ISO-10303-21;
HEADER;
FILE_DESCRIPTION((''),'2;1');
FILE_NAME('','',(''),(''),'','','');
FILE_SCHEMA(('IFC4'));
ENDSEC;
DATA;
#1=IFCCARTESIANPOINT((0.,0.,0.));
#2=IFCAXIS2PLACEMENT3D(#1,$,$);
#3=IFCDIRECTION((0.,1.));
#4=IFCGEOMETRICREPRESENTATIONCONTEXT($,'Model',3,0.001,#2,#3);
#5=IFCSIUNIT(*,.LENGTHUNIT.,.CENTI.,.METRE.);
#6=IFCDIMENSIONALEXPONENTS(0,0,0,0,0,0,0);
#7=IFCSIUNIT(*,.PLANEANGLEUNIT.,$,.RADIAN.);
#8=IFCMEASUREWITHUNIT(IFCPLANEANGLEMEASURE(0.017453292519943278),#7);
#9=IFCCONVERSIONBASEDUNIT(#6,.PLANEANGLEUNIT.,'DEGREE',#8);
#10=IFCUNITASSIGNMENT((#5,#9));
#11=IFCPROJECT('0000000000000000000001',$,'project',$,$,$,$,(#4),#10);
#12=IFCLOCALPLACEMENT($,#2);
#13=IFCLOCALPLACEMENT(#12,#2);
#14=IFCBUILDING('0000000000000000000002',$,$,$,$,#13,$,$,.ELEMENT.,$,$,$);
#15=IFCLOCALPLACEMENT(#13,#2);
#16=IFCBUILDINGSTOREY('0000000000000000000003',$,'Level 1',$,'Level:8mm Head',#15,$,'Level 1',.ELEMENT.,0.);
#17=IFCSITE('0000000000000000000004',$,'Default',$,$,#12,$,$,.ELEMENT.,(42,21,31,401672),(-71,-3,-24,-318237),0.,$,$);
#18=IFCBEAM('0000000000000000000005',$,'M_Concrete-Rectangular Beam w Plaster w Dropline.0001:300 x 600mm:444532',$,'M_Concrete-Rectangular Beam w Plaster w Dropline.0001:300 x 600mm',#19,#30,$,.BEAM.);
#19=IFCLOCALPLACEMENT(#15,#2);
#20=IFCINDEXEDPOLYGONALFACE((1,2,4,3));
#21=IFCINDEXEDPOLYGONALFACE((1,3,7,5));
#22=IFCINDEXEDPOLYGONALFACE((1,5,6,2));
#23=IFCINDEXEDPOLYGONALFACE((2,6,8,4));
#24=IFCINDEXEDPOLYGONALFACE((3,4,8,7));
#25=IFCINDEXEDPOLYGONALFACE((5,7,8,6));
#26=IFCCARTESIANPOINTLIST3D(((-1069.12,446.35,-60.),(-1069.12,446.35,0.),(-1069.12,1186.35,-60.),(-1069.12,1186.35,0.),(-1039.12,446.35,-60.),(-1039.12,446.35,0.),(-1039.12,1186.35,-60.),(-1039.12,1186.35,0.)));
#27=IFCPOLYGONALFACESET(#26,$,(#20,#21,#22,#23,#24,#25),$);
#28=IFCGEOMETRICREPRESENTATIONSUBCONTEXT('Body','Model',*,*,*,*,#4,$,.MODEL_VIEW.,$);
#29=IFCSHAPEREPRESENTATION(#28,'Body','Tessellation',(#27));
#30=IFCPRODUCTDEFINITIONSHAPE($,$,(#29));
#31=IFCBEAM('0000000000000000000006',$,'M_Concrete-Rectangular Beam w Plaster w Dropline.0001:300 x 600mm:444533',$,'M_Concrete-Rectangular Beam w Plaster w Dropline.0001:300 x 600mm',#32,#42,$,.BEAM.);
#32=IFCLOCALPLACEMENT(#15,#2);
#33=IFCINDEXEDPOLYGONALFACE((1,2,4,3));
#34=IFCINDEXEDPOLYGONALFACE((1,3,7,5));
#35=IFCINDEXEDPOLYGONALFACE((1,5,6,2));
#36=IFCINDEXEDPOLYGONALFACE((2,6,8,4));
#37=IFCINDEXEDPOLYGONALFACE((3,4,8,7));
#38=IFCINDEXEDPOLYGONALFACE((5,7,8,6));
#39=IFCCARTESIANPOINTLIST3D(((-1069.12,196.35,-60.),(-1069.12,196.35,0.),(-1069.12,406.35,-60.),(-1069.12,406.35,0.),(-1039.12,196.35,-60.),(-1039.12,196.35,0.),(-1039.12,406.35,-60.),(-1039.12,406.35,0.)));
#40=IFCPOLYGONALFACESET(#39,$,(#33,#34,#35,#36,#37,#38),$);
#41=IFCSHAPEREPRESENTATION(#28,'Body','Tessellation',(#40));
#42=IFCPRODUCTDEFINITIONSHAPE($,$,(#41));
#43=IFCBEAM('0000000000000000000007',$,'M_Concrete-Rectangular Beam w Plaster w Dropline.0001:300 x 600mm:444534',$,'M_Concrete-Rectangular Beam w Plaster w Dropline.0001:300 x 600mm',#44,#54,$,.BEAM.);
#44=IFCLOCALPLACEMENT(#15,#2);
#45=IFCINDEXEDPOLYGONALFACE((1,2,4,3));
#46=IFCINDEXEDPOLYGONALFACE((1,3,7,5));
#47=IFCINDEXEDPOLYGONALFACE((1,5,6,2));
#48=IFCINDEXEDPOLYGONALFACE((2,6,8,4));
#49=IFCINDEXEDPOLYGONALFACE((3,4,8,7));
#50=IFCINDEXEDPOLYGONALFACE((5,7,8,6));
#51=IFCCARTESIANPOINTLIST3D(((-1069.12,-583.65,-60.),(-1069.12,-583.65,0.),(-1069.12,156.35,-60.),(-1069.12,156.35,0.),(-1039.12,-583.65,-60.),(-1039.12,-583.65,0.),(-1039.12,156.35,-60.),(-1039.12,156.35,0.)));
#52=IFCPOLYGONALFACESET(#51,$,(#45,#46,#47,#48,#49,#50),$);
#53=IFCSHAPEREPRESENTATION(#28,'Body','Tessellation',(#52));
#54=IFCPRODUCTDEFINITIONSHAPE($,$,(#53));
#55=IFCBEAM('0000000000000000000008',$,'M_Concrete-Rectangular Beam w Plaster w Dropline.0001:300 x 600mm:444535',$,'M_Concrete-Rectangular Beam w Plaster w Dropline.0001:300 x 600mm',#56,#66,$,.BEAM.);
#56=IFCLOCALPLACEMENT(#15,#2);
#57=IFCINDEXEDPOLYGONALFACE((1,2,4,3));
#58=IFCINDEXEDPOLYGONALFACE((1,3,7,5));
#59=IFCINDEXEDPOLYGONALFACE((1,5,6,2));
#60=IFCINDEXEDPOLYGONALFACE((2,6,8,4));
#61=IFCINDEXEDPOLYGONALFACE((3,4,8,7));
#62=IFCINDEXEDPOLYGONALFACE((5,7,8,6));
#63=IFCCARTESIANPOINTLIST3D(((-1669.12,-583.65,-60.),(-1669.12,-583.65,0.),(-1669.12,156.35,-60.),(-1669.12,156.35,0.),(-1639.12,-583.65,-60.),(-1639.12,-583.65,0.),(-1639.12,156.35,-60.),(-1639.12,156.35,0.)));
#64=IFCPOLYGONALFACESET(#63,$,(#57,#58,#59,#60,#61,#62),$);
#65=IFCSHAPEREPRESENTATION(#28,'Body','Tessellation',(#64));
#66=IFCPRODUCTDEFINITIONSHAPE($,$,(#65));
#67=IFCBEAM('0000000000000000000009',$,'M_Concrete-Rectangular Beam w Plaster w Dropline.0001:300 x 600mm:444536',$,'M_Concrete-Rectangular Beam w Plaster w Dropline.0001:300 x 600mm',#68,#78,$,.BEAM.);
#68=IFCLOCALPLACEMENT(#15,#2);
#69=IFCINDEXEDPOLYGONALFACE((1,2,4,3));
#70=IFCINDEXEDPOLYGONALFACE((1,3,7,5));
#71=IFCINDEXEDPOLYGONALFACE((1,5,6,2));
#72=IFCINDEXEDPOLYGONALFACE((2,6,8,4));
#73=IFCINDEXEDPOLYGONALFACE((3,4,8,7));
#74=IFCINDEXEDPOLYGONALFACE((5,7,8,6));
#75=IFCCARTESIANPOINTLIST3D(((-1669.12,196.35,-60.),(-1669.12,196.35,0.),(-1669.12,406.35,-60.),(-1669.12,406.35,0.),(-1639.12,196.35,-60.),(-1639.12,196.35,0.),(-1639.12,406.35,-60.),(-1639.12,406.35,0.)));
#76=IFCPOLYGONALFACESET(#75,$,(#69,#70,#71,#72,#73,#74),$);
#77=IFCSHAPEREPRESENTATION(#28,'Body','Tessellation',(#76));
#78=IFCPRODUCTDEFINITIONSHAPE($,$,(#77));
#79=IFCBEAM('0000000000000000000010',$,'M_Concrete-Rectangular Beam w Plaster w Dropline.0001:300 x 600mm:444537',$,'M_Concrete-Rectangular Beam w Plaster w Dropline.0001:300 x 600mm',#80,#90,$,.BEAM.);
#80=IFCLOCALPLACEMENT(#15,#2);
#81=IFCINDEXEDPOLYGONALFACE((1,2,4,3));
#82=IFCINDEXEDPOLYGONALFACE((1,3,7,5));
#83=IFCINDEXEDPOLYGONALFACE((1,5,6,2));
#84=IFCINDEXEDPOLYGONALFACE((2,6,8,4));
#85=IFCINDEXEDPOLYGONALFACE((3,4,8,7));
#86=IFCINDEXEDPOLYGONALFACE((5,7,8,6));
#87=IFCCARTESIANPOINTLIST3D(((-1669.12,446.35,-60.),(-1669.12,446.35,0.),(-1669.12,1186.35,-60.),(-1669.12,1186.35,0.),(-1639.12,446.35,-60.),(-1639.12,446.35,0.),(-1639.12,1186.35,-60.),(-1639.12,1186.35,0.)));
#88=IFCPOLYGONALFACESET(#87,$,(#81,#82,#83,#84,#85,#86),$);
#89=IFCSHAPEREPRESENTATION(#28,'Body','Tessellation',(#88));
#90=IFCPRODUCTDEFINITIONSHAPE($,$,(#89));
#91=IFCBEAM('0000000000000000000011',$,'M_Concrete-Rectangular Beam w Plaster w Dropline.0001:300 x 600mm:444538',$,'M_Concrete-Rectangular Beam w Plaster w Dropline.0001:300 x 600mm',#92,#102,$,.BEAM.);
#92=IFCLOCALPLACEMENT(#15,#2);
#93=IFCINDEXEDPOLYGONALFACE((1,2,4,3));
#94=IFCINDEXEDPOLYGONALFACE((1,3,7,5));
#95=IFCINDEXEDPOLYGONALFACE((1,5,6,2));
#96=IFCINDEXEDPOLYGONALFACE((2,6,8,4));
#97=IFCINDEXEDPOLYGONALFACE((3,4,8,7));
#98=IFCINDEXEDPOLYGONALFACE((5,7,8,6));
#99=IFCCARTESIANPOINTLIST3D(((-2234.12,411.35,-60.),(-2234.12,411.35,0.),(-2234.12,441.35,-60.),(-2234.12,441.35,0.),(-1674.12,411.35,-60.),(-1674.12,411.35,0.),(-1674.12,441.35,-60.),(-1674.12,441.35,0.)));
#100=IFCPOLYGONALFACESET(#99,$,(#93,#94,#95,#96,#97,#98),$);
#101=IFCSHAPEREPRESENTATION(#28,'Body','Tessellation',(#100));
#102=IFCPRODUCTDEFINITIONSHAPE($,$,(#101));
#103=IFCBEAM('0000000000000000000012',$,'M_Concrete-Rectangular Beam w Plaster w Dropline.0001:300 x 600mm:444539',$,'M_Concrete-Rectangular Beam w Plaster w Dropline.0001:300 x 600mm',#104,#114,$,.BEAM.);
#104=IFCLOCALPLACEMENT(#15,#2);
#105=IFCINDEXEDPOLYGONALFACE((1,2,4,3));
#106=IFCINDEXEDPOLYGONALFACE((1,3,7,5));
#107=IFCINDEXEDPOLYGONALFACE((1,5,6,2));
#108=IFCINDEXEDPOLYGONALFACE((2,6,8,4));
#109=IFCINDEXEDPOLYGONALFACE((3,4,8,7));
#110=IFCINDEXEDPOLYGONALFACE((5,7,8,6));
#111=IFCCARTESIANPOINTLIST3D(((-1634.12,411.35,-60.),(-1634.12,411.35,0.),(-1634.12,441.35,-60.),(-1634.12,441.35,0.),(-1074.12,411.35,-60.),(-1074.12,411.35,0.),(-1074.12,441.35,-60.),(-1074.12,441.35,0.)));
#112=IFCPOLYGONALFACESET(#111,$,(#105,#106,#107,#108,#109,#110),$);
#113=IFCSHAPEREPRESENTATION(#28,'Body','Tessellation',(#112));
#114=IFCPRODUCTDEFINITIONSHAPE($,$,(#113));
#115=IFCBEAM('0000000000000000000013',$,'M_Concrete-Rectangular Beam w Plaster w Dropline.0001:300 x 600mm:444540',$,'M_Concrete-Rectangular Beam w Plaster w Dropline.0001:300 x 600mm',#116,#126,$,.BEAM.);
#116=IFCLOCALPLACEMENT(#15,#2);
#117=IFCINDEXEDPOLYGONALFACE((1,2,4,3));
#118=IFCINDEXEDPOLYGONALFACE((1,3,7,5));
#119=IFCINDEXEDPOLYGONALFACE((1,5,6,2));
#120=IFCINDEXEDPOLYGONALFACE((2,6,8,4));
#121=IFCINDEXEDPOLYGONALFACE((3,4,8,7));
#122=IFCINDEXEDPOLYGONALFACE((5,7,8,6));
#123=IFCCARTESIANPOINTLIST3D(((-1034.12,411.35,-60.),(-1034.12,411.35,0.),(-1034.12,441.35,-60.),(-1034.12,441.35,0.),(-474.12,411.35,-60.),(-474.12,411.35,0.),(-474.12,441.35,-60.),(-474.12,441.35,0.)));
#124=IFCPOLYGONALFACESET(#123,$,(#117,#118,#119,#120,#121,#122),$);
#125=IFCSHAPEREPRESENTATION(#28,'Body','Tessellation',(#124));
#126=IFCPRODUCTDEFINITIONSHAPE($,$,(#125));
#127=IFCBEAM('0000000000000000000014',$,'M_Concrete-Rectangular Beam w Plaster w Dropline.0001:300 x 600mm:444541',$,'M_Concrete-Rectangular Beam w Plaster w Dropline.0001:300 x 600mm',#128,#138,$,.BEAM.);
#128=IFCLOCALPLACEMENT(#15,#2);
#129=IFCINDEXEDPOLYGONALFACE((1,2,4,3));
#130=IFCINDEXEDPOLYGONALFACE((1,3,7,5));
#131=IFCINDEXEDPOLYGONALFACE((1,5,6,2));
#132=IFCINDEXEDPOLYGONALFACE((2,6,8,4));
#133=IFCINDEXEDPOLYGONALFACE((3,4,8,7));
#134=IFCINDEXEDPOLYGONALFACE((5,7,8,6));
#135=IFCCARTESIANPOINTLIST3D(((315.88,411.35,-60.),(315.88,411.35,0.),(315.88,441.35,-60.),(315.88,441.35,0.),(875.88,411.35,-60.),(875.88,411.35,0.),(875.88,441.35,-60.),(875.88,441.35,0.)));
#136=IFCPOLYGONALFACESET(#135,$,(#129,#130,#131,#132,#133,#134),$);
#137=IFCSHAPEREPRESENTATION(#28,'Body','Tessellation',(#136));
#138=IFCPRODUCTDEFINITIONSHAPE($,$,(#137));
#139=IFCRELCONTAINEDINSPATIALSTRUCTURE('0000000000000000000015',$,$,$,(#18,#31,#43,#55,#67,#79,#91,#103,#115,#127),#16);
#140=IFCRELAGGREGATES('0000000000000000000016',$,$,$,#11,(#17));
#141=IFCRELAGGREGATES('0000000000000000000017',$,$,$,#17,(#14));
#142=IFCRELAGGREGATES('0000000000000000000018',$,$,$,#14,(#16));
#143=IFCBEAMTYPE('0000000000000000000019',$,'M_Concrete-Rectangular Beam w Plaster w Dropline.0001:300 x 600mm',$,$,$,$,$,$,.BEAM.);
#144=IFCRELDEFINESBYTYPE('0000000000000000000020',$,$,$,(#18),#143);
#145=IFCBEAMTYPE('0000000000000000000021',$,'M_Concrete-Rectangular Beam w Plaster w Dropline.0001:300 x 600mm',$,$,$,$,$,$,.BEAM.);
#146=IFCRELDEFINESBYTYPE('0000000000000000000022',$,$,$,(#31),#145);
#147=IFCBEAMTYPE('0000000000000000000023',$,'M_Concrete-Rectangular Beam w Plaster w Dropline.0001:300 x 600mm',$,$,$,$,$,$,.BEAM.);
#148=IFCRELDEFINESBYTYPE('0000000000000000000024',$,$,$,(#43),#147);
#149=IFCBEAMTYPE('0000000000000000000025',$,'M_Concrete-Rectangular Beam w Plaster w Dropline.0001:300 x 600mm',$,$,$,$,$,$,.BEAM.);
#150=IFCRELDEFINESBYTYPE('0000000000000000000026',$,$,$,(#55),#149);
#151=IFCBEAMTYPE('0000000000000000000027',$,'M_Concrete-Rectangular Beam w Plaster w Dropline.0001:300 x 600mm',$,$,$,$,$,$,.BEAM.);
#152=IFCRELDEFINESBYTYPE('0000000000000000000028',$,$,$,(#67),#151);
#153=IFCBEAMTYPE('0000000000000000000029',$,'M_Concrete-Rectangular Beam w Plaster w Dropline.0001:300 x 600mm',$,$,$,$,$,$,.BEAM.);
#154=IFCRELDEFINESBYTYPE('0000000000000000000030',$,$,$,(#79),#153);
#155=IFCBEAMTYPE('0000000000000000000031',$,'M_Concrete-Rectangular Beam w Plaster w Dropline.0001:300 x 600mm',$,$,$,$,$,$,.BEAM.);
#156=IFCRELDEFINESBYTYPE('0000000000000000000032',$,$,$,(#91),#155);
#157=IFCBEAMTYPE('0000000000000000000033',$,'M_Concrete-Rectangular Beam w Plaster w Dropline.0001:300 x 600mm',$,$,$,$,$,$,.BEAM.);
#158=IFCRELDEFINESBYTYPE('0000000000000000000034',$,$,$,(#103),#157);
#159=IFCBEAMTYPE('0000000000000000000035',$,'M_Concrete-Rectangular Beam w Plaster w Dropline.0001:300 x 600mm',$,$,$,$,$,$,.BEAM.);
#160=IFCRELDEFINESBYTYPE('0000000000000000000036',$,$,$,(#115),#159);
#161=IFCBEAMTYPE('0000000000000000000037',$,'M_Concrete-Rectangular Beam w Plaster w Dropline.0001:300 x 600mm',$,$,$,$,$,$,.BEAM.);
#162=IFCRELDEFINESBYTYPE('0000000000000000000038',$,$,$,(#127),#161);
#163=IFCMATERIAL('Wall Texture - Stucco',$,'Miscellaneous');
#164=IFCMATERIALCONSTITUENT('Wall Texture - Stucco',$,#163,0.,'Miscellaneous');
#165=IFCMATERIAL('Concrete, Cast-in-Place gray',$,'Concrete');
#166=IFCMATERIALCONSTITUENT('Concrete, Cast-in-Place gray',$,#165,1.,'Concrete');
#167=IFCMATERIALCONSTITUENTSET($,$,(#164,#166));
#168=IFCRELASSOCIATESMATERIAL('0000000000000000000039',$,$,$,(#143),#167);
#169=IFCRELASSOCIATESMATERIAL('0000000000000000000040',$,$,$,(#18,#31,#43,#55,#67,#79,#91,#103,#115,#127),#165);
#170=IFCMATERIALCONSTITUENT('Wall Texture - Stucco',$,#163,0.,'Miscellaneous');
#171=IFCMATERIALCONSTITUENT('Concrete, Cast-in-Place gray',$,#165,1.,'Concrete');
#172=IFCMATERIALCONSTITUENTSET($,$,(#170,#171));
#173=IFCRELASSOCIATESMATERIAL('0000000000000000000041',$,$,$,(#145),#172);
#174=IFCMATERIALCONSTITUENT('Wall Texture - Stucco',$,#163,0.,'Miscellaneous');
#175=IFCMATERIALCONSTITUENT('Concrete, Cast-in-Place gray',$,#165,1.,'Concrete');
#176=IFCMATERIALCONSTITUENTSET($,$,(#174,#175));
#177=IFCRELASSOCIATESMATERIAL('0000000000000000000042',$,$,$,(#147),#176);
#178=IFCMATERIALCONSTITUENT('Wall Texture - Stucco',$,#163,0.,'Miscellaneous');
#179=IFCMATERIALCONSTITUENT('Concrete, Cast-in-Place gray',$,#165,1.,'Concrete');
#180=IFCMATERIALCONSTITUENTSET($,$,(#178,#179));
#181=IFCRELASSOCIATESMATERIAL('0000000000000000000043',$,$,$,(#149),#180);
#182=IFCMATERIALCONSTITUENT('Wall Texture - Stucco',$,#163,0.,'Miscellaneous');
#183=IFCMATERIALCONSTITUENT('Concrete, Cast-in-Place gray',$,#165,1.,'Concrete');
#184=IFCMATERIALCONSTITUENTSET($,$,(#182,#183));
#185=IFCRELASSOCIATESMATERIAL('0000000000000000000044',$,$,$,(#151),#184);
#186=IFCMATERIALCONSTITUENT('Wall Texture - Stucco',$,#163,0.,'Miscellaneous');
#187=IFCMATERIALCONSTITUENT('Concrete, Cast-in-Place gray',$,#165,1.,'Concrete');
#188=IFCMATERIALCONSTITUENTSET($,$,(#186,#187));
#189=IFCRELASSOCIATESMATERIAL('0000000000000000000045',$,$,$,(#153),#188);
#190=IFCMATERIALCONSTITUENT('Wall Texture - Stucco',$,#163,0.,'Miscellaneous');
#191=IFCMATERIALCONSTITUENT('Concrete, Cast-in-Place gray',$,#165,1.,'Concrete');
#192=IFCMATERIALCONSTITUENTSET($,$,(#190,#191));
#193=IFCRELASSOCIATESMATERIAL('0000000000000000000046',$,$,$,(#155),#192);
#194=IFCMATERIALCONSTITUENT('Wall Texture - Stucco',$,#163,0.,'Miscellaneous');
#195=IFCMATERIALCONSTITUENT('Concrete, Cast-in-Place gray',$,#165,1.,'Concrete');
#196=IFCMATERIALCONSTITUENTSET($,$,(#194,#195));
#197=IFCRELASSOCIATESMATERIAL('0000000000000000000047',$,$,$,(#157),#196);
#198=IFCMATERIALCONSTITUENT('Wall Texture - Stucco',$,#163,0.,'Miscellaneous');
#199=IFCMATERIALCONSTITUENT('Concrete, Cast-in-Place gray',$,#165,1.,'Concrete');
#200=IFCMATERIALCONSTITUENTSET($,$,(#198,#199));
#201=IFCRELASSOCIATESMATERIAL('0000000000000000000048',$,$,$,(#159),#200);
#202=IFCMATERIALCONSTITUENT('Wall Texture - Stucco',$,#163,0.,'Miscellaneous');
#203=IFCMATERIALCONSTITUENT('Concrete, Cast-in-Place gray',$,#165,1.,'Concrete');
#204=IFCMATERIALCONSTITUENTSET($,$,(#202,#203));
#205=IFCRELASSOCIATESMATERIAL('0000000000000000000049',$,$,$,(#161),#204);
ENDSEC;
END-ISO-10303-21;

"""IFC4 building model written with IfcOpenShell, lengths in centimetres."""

from ifc_helpers import new_model, entity, si_unit, converted_unit, direction, frame, origin, place, context, subcontext, project, spatial, indexed_curve, outline, extrude, source, transform, mapped, material, constituent, constituent_set, type_object, type_shapes, element, save


model = new_model("IFC4")

# Units and contexts
model_context = context("Model", 3, precision=0.001, world=origin(), true_north=direction((0.0, 1.0)))
body_context = subcontext(model_context, "Body", "Model", "MODEL_VIEW")
ifc_project = project(units=[si_unit("LENGTHUNIT", "METRE", prefix="CENTI"), converted_unit("PLANEANGLEUNIT", "DEGREE", entity("IfcPlaneAngleMeasure", 0.017453292519943278), si_unit("PLANEANGLEUNIT", "RADIAN"), dimensions=[0, 0, 0, 0, 0, 0, 0])], contexts=[model_context])

# Site, building, storey
site_placement = place(None, origin())
site = spatial("IfcSite", under=ifc_project, at=site_placement, Name="Default", CompositionType="ELEMENT", RefLatitude=(42, 21, 31, 401672), RefLongitude=(-71, -3, -24, -318237), RefElevation=0.0)
building_placement = place(site_placement, origin())
building = spatial("IfcBuilding", under=site, at=building_placement, CompositionType="ELEMENT")
storey_placement = place(building_placement, origin())
storey = spatial("IfcBuildingStorey", under=building, at=storey_placement, Name="Level 1", ObjectType="Level:8mm Head", LongName="Level 1", CompositionType="ELEMENT", Elevation=0.0)

# Beams
ifc_material_1 = material(Name="Concrete, Cast-in-Place gray", Category="Concrete")
ifc_material_2 = material(Name="Wall Texture - Stucco", Category="Miscellaneous")
ifc_constituent_1 = constituent(ifc_material_2, Name="Wall Texture - Stucco", Category="Miscellaneous", fraction=0.0)
ifc_constituent_2 = constituent(ifc_material_1, Name="Concrete, Cast-in-Place gray", Category="Concrete", fraction=1.0)
ifc_constituent_set_1 = constituent_set(constituents=[ifc_constituent_1, ifc_constituent_2])
beam_type_1 = type_object("IfcBeamType", Name="M_Concrete-Rectangular Beam w Plaster w Dropline.0001:300 x 600mm", PredefinedType="BEAM", material=ifc_constituent_set_1)
shared_shape_1 = source(origin(), body_context, "Body", "SweptSolid", [
    extrude(outline(indexed_curve([(-15.0, -30.0), (15.0, -30.0), (15.0, 30.0), (-15.0, 30.0), (-15.0, -30.0)], self_intersect=False)), frame((-1054.12, 1186.35, -30.0), z_axis=(0.0, -1.0, 0.0), x_axis=(-1.0, 0.0, 0.0)), (0.0, 0.0, 1.0), 740.0),
])
type_shapes(beam_type_1, [shared_shape_1])
beam_1_placement = place(storey_placement, origin())
element("IfcBeam", 1, at=beam_1_placement, inside=storey, type_object=beam_type_1, material=ifc_material_1, Name="M_Concrete-Rectangular Beam w Plaster w Dropline.0001:300 x 600mm:444532", ObjectType="M_Concrete-Rectangular Beam w Plaster w Dropline.0001:300 x 600mm", PredefinedType="BEAM", context=body_context, shape_type="MappedRepresentation", body=[
    mapped(shared_shape_1, transform((0.0, 0.0, 0.0), scale=1.0)),
])
ifc_constituent_3 = constituent(ifc_material_2, Name="Wall Texture - Stucco", Category="Miscellaneous", fraction=0.0)
ifc_constituent_4 = constituent(ifc_material_1, Name="Concrete, Cast-in-Place gray", Category="Concrete", fraction=1.0)
ifc_constituent_set_2 = constituent_set(constituents=[ifc_constituent_3, ifc_constituent_4])
beam_type_2 = type_object("IfcBeamType", Name="M_Concrete-Rectangular Beam w Plaster w Dropline.0001:300 x 600mm", PredefinedType="BEAM", material=ifc_constituent_set_2)
shared_shape_2 = source(origin(), body_context, "Body", "SweptSolid", [
    extrude(outline(indexed_curve([(-15.0, -30.0), (15.0, -30.0), (15.0, 30.0), (-15.0, 30.0), (-15.0, -30.0)], self_intersect=False)), frame((-1054.12, 406.35, -30.0), z_axis=(0.0, -1.0, 0.0), x_axis=(-1.0, 0.0, 0.0)), (0.0, 0.0, 1.0), 210.0),
])
type_shapes(beam_type_2, [shared_shape_2])
beam_2_placement = place(storey_placement, origin())
element("IfcBeam", 2, at=beam_2_placement, inside=storey, type_object=beam_type_2, material=ifc_material_1, Name="M_Concrete-Rectangular Beam w Plaster w Dropline.0001:300 x 600mm:444533", ObjectType="M_Concrete-Rectangular Beam w Plaster w Dropline.0001:300 x 600mm", PredefinedType="BEAM", context=body_context, shape_type="MappedRepresentation", body=[
    mapped(shared_shape_2, transform((0.0, 0.0, 0.0), scale=1.0)),
])
ifc_constituent_5 = constituent(ifc_material_2, Name="Wall Texture - Stucco", Category="Miscellaneous", fraction=0.0)
ifc_constituent_6 = constituent(ifc_material_1, Name="Concrete, Cast-in-Place gray", Category="Concrete", fraction=1.0)
ifc_constituent_set_3 = constituent_set(constituents=[ifc_constituent_5, ifc_constituent_6])
beam_type_3 = type_object("IfcBeamType", Name="M_Concrete-Rectangular Beam w Plaster w Dropline.0001:300 x 600mm", PredefinedType="BEAM", material=ifc_constituent_set_3)
shared_shape_3 = source(origin(), body_context, "Body", "SweptSolid", [
    extrude(outline(indexed_curve([(-15.0, -30.0), (15.0, -30.0), (15.0, 30.0), (-15.0, 30.0), (-15.0, -30.0)], self_intersect=False)), frame((-1054.12, 156.35, -30.0), z_axis=(0.0, -1.0, 0.0), x_axis=(-1.0, 0.0, 0.0)), (0.0, 0.0, 1.0), 740.0),
])
type_shapes(beam_type_3, [shared_shape_3])
beam_3_placement = place(storey_placement, origin())
element("IfcBeam", 3, at=beam_3_placement, inside=storey, type_object=beam_type_3, material=ifc_material_1, Name="M_Concrete-Rectangular Beam w Plaster w Dropline.0001:300 x 600mm:444534", ObjectType="M_Concrete-Rectangular Beam w Plaster w Dropline.0001:300 x 600mm", PredefinedType="BEAM", context=body_context, shape_type="MappedRepresentation", body=[
    mapped(shared_shape_3, transform((0.0, 0.0, 0.0), scale=1.0)),
])
ifc_constituent_7 = constituent(ifc_material_2, Name="Wall Texture - Stucco", Category="Miscellaneous", fraction=0.0)
ifc_constituent_8 = constituent(ifc_material_1, Name="Concrete, Cast-in-Place gray", Category="Concrete", fraction=1.0)
ifc_constituent_set_4 = constituent_set(constituents=[ifc_constituent_7, ifc_constituent_8])
beam_type_4 = type_object("IfcBeamType", Name="M_Concrete-Rectangular Beam w Plaster w Dropline.0001:300 x 600mm", PredefinedType="BEAM", material=ifc_constituent_set_4)
shared_shape_4 = source(origin(), body_context, "Body", "SweptSolid", [
    extrude(outline(indexed_curve([(-15.0, -30.0), (15.0, -30.0), (15.0, 30.0), (-15.0, 30.0), (-15.0, -30.0)], self_intersect=False)), frame((-1654.12, -583.65, -30.0), z_axis=(0.0, 1.0, 0.0), x_axis=(-1.0, 0.0, 0.0)), (0.0, 0.0, 1.0), 740.0),
])
type_shapes(beam_type_4, [shared_shape_4])
beam_4_placement = place(storey_placement, origin())
element("IfcBeam", 4, at=beam_4_placement, inside=storey, type_object=beam_type_4, material=ifc_material_1, Name="M_Concrete-Rectangular Beam w Plaster w Dropline.0001:300 x 600mm:444535", ObjectType="M_Concrete-Rectangular Beam w Plaster w Dropline.0001:300 x 600mm", PredefinedType="BEAM", context=body_context, shape_type="MappedRepresentation", body=[
    mapped(shared_shape_4, transform((0.0, 0.0, 0.0), scale=1.0)),
])
ifc_constituent_9 = constituent(ifc_material_2, Name="Wall Texture - Stucco", Category="Miscellaneous", fraction=0.0)
ifc_constituent_10 = constituent(ifc_material_1, Name="Concrete, Cast-in-Place gray", Category="Concrete", fraction=1.0)
ifc_constituent_set_5 = constituent_set(constituents=[ifc_constituent_9, ifc_constituent_10])
beam_type_5 = type_object("IfcBeamType", Name="M_Concrete-Rectangular Beam w Plaster w Dropline.0001:300 x 600mm", PredefinedType="BEAM", material=ifc_constituent_set_5)
shared_shape_5 = source(origin(), body_context, "Body", "SweptSolid", [
    extrude(outline(indexed_curve([(-15.0, -30.0), (15.0, -30.0), (15.0, 30.0), (-15.0, 30.0), (-15.0, -30.0)], self_intersect=False)), frame((-1654.12, 196.35, -30.0), z_axis=(0.0, 1.0, 0.0), x_axis=(-1.0, 0.0, 0.0)), (0.0, 0.0, 1.0), 210.0),
])
type_shapes(beam_type_5, [shared_shape_5])
beam_5_placement = place(storey_placement, origin())
element("IfcBeam", 5, at=beam_5_placement, inside=storey, type_object=beam_type_5, material=ifc_material_1, Name="M_Concrete-Rectangular Beam w Plaster w Dropline.0001:300 x 600mm:444536", ObjectType="M_Concrete-Rectangular Beam w Plaster w Dropline.0001:300 x 600mm", PredefinedType="BEAM", context=body_context, shape_type="MappedRepresentation", body=[
    mapped(shared_shape_5, transform((0.0, 0.0, 0.0), scale=1.0)),
])
ifc_constituent_11 = constituent(ifc_material_2, Name="Wall Texture - Stucco", Category="Miscellaneous", fraction=0.0)
ifc_constituent_12 = constituent(ifc_material_1, Name="Concrete, Cast-in-Place gray", Category="Concrete", fraction=1.0)
ifc_constituent_set_6 = constituent_set(constituents=[ifc_constituent_11, ifc_constituent_12])
beam_type_6 = type_object("IfcBeamType", Name="M_Concrete-Rectangular Beam w Plaster w Dropline.0001:300 x 600mm", PredefinedType="BEAM", material=ifc_constituent_set_6)
shared_shape_6 = source(origin(), body_context, "Body", "SweptSolid", [
    extrude(outline(indexed_curve([(-15.0, -30.0), (15.0, -30.0), (15.0, 30.0), (-15.0, 30.0), (-15.0, -30.0)], self_intersect=False)), frame((-1654.12, 446.35, -30.0), z_axis=(0.0, 1.0, 0.0), x_axis=(-1.0, 0.0, 0.0)), (0.0, 0.0, 1.0), 740.0),
])
type_shapes(beam_type_6, [shared_shape_6])
beam_6_placement = place(storey_placement, origin())
element("IfcBeam", 6, at=beam_6_placement, inside=storey, type_object=beam_type_6, material=ifc_material_1, Name="M_Concrete-Rectangular Beam w Plaster w Dropline.0001:300 x 600mm:444537", ObjectType="M_Concrete-Rectangular Beam w Plaster w Dropline.0001:300 x 600mm", PredefinedType="BEAM", context=body_context, shape_type="MappedRepresentation", body=[
    mapped(shared_shape_6, transform((0.0, 0.0, 0.0), scale=1.0)),
])
ifc_constituent_13 = constituent(ifc_material_2, Name="Wall Texture - Stucco", Category="Miscellaneous", fraction=0.0)
ifc_constituent_14 = constituent(ifc_material_1, Name="Concrete, Cast-in-Place gray", Category="Concrete", fraction=1.0)
ifc_constituent_set_7 = constituent_set(constituents=[ifc_constituent_13, ifc_constituent_14])
beam_type_7 = type_object("IfcBeamType", Name="M_Concrete-Rectangular Beam w Plaster w Dropline.0001:300 x 600mm", PredefinedType="BEAM", material=ifc_constituent_set_7)
shared_shape_7 = source(origin(), body_context, "Body", "SweptSolid", [
    extrude(outline(indexed_curve([(-30.0, -15.0), (30.0, -15.0), (30.0, 15.0), (-30.0, 15.0), (-30.0, -15.0)], self_intersect=False)), frame((-2234.12, 426.35, -30.0), z_axis=(1.0, 0.0, 0.0), x_axis=(0.0, 0.0, -1.0)), (0.0, 0.0, 1.0), 560.0),
])
type_shapes(beam_type_7, [shared_shape_7])
beam_7_placement = place(storey_placement, origin())
element("IfcBeam", 7, at=beam_7_placement, inside=storey, type_object=beam_type_7, material=ifc_material_1, Name="M_Concrete-Rectangular Beam w Plaster w Dropline.0001:300 x 600mm:444538", ObjectType="M_Concrete-Rectangular Beam w Plaster w Dropline.0001:300 x 600mm", PredefinedType="BEAM", context=body_context, shape_type="MappedRepresentation", body=[
    mapped(shared_shape_7, transform((0.0, 0.0, 0.0), scale=1.0)),
])
ifc_constituent_15 = constituent(ifc_material_2, Name="Wall Texture - Stucco", Category="Miscellaneous", fraction=0.0)
ifc_constituent_16 = constituent(ifc_material_1, Name="Concrete, Cast-in-Place gray", Category="Concrete", fraction=1.0)
ifc_constituent_set_8 = constituent_set(constituents=[ifc_constituent_15, ifc_constituent_16])
beam_type_8 = type_object("IfcBeamType", Name="M_Concrete-Rectangular Beam w Plaster w Dropline.0001:300 x 600mm", PredefinedType="BEAM", material=ifc_constituent_set_8)
shared_shape_8 = source(origin(), body_context, "Body", "SweptSolid", [
    extrude(outline(indexed_curve([(-30.0, -15.0), (30.0, -15.0), (30.0, 15.0), (-30.0, 15.0), (-30.0, -15.0)], self_intersect=False)), frame((-1634.12, 426.35, -30.0), z_axis=(1.0, 0.0, 0.0), x_axis=(0.0, 0.0, -1.0)), (0.0, 0.0, 1.0), 560.0),
])
type_shapes(beam_type_8, [shared_shape_8])
beam_8_placement = place(storey_placement, origin())
element("IfcBeam", 8, at=beam_8_placement, inside=storey, type_object=beam_type_8, material=ifc_material_1, Name="M_Concrete-Rectangular Beam w Plaster w Dropline.0001:300 x 600mm:444539", ObjectType="M_Concrete-Rectangular Beam w Plaster w Dropline.0001:300 x 600mm", PredefinedType="BEAM", context=body_context, shape_type="MappedRepresentation", body=[
    mapped(shared_shape_8, transform((0.0, 0.0, 0.0), scale=1.0)),
])
ifc_constituent_17 = constituent(ifc_material_2, Name="Wall Texture - Stucco", Category="Miscellaneous", fraction=0.0)
ifc_constituent_18 = constituent(ifc_material_1, Name="Concrete, Cast-in-Place gray", Category="Concrete", fraction=1.0)
ifc_constituent_set_9 = constituent_set(constituents=[ifc_constituent_17, ifc_constituent_18])
beam_type_9 = type_object("IfcBeamType", Name="M_Concrete-Rectangular Beam w Plaster w Dropline.0001:300 x 600mm", PredefinedType="BEAM", material=ifc_constituent_set_9)
shared_shape_9 = source(origin(), body_context, "Body", "SweptSolid", [
    extrude(outline(indexed_curve([(-30.0, -15.0), (30.0, -15.0), (30.0, 15.0), (-30.0, 15.0), (-30.0, -15.0)], self_intersect=False)), frame((-1034.12, 426.35, -30.0), z_axis=(1.0, 0.0, 0.0), x_axis=(0.0, 0.0, -1.0)), (0.0, 0.0, 1.0), 560.0),
])
type_shapes(beam_type_9, [shared_shape_9])
beam_9_placement = place(storey_placement, origin())
element("IfcBeam", 9, at=beam_9_placement, inside=storey, type_object=beam_type_9, material=ifc_material_1, Name="M_Concrete-Rectangular Beam w Plaster w Dropline.0001:300 x 600mm:444540", ObjectType="M_Concrete-Rectangular Beam w Plaster w Dropline.0001:300 x 600mm", PredefinedType="BEAM", context=body_context, shape_type="MappedRepresentation", body=[
    mapped(shared_shape_9, transform((0.0, 0.0, 0.0), scale=1.0)),
])
ifc_constituent_19 = constituent(ifc_material_2, Name="Wall Texture - Stucco", Category="Miscellaneous", fraction=0.0)
ifc_constituent_20 = constituent(ifc_material_1, Name="Concrete, Cast-in-Place gray", Category="Concrete", fraction=1.0)
ifc_constituent_set_10 = constituent_set(constituents=[ifc_constituent_19, ifc_constituent_20])
beam_type_10 = type_object("IfcBeamType", Name="M_Concrete-Rectangular Beam w Plaster w Dropline.0001:300 x 600mm", PredefinedType="BEAM", material=ifc_constituent_set_10)
shared_shape_10 = source(origin(), body_context, "Body", "SweptSolid", [
    extrude(outline(indexed_curve([(-30.0, -15.0), (30.0, -15.0), (30.0, 15.0), (-30.0, 15.0), (-30.0, -15.0)], self_intersect=False)), frame((315.88, 426.35, -30.0), z_axis=(1.0, 0.0, 0.0), x_axis=(0.0, 0.0, -1.0)), (0.0, 0.0, 1.0), 560.0),
])
type_shapes(beam_type_10, [shared_shape_10])
beam_10_placement = place(storey_placement, origin())
element("IfcBeam", 10, at=beam_10_placement, inside=storey, type_object=beam_type_10, material=ifc_material_1, Name="M_Concrete-Rectangular Beam w Plaster w Dropline.0001:300 x 600mm:444541", ObjectType="M_Concrete-Rectangular Beam w Plaster w Dropline.0001:300 x 600mm", PredefinedType="BEAM", context=body_context, shape_type="MappedRepresentation", body=[
    mapped(shared_shape_10, transform((0.0, 0.0, 0.0), scale=1.0)),
])

save(model, "model.ifc")
